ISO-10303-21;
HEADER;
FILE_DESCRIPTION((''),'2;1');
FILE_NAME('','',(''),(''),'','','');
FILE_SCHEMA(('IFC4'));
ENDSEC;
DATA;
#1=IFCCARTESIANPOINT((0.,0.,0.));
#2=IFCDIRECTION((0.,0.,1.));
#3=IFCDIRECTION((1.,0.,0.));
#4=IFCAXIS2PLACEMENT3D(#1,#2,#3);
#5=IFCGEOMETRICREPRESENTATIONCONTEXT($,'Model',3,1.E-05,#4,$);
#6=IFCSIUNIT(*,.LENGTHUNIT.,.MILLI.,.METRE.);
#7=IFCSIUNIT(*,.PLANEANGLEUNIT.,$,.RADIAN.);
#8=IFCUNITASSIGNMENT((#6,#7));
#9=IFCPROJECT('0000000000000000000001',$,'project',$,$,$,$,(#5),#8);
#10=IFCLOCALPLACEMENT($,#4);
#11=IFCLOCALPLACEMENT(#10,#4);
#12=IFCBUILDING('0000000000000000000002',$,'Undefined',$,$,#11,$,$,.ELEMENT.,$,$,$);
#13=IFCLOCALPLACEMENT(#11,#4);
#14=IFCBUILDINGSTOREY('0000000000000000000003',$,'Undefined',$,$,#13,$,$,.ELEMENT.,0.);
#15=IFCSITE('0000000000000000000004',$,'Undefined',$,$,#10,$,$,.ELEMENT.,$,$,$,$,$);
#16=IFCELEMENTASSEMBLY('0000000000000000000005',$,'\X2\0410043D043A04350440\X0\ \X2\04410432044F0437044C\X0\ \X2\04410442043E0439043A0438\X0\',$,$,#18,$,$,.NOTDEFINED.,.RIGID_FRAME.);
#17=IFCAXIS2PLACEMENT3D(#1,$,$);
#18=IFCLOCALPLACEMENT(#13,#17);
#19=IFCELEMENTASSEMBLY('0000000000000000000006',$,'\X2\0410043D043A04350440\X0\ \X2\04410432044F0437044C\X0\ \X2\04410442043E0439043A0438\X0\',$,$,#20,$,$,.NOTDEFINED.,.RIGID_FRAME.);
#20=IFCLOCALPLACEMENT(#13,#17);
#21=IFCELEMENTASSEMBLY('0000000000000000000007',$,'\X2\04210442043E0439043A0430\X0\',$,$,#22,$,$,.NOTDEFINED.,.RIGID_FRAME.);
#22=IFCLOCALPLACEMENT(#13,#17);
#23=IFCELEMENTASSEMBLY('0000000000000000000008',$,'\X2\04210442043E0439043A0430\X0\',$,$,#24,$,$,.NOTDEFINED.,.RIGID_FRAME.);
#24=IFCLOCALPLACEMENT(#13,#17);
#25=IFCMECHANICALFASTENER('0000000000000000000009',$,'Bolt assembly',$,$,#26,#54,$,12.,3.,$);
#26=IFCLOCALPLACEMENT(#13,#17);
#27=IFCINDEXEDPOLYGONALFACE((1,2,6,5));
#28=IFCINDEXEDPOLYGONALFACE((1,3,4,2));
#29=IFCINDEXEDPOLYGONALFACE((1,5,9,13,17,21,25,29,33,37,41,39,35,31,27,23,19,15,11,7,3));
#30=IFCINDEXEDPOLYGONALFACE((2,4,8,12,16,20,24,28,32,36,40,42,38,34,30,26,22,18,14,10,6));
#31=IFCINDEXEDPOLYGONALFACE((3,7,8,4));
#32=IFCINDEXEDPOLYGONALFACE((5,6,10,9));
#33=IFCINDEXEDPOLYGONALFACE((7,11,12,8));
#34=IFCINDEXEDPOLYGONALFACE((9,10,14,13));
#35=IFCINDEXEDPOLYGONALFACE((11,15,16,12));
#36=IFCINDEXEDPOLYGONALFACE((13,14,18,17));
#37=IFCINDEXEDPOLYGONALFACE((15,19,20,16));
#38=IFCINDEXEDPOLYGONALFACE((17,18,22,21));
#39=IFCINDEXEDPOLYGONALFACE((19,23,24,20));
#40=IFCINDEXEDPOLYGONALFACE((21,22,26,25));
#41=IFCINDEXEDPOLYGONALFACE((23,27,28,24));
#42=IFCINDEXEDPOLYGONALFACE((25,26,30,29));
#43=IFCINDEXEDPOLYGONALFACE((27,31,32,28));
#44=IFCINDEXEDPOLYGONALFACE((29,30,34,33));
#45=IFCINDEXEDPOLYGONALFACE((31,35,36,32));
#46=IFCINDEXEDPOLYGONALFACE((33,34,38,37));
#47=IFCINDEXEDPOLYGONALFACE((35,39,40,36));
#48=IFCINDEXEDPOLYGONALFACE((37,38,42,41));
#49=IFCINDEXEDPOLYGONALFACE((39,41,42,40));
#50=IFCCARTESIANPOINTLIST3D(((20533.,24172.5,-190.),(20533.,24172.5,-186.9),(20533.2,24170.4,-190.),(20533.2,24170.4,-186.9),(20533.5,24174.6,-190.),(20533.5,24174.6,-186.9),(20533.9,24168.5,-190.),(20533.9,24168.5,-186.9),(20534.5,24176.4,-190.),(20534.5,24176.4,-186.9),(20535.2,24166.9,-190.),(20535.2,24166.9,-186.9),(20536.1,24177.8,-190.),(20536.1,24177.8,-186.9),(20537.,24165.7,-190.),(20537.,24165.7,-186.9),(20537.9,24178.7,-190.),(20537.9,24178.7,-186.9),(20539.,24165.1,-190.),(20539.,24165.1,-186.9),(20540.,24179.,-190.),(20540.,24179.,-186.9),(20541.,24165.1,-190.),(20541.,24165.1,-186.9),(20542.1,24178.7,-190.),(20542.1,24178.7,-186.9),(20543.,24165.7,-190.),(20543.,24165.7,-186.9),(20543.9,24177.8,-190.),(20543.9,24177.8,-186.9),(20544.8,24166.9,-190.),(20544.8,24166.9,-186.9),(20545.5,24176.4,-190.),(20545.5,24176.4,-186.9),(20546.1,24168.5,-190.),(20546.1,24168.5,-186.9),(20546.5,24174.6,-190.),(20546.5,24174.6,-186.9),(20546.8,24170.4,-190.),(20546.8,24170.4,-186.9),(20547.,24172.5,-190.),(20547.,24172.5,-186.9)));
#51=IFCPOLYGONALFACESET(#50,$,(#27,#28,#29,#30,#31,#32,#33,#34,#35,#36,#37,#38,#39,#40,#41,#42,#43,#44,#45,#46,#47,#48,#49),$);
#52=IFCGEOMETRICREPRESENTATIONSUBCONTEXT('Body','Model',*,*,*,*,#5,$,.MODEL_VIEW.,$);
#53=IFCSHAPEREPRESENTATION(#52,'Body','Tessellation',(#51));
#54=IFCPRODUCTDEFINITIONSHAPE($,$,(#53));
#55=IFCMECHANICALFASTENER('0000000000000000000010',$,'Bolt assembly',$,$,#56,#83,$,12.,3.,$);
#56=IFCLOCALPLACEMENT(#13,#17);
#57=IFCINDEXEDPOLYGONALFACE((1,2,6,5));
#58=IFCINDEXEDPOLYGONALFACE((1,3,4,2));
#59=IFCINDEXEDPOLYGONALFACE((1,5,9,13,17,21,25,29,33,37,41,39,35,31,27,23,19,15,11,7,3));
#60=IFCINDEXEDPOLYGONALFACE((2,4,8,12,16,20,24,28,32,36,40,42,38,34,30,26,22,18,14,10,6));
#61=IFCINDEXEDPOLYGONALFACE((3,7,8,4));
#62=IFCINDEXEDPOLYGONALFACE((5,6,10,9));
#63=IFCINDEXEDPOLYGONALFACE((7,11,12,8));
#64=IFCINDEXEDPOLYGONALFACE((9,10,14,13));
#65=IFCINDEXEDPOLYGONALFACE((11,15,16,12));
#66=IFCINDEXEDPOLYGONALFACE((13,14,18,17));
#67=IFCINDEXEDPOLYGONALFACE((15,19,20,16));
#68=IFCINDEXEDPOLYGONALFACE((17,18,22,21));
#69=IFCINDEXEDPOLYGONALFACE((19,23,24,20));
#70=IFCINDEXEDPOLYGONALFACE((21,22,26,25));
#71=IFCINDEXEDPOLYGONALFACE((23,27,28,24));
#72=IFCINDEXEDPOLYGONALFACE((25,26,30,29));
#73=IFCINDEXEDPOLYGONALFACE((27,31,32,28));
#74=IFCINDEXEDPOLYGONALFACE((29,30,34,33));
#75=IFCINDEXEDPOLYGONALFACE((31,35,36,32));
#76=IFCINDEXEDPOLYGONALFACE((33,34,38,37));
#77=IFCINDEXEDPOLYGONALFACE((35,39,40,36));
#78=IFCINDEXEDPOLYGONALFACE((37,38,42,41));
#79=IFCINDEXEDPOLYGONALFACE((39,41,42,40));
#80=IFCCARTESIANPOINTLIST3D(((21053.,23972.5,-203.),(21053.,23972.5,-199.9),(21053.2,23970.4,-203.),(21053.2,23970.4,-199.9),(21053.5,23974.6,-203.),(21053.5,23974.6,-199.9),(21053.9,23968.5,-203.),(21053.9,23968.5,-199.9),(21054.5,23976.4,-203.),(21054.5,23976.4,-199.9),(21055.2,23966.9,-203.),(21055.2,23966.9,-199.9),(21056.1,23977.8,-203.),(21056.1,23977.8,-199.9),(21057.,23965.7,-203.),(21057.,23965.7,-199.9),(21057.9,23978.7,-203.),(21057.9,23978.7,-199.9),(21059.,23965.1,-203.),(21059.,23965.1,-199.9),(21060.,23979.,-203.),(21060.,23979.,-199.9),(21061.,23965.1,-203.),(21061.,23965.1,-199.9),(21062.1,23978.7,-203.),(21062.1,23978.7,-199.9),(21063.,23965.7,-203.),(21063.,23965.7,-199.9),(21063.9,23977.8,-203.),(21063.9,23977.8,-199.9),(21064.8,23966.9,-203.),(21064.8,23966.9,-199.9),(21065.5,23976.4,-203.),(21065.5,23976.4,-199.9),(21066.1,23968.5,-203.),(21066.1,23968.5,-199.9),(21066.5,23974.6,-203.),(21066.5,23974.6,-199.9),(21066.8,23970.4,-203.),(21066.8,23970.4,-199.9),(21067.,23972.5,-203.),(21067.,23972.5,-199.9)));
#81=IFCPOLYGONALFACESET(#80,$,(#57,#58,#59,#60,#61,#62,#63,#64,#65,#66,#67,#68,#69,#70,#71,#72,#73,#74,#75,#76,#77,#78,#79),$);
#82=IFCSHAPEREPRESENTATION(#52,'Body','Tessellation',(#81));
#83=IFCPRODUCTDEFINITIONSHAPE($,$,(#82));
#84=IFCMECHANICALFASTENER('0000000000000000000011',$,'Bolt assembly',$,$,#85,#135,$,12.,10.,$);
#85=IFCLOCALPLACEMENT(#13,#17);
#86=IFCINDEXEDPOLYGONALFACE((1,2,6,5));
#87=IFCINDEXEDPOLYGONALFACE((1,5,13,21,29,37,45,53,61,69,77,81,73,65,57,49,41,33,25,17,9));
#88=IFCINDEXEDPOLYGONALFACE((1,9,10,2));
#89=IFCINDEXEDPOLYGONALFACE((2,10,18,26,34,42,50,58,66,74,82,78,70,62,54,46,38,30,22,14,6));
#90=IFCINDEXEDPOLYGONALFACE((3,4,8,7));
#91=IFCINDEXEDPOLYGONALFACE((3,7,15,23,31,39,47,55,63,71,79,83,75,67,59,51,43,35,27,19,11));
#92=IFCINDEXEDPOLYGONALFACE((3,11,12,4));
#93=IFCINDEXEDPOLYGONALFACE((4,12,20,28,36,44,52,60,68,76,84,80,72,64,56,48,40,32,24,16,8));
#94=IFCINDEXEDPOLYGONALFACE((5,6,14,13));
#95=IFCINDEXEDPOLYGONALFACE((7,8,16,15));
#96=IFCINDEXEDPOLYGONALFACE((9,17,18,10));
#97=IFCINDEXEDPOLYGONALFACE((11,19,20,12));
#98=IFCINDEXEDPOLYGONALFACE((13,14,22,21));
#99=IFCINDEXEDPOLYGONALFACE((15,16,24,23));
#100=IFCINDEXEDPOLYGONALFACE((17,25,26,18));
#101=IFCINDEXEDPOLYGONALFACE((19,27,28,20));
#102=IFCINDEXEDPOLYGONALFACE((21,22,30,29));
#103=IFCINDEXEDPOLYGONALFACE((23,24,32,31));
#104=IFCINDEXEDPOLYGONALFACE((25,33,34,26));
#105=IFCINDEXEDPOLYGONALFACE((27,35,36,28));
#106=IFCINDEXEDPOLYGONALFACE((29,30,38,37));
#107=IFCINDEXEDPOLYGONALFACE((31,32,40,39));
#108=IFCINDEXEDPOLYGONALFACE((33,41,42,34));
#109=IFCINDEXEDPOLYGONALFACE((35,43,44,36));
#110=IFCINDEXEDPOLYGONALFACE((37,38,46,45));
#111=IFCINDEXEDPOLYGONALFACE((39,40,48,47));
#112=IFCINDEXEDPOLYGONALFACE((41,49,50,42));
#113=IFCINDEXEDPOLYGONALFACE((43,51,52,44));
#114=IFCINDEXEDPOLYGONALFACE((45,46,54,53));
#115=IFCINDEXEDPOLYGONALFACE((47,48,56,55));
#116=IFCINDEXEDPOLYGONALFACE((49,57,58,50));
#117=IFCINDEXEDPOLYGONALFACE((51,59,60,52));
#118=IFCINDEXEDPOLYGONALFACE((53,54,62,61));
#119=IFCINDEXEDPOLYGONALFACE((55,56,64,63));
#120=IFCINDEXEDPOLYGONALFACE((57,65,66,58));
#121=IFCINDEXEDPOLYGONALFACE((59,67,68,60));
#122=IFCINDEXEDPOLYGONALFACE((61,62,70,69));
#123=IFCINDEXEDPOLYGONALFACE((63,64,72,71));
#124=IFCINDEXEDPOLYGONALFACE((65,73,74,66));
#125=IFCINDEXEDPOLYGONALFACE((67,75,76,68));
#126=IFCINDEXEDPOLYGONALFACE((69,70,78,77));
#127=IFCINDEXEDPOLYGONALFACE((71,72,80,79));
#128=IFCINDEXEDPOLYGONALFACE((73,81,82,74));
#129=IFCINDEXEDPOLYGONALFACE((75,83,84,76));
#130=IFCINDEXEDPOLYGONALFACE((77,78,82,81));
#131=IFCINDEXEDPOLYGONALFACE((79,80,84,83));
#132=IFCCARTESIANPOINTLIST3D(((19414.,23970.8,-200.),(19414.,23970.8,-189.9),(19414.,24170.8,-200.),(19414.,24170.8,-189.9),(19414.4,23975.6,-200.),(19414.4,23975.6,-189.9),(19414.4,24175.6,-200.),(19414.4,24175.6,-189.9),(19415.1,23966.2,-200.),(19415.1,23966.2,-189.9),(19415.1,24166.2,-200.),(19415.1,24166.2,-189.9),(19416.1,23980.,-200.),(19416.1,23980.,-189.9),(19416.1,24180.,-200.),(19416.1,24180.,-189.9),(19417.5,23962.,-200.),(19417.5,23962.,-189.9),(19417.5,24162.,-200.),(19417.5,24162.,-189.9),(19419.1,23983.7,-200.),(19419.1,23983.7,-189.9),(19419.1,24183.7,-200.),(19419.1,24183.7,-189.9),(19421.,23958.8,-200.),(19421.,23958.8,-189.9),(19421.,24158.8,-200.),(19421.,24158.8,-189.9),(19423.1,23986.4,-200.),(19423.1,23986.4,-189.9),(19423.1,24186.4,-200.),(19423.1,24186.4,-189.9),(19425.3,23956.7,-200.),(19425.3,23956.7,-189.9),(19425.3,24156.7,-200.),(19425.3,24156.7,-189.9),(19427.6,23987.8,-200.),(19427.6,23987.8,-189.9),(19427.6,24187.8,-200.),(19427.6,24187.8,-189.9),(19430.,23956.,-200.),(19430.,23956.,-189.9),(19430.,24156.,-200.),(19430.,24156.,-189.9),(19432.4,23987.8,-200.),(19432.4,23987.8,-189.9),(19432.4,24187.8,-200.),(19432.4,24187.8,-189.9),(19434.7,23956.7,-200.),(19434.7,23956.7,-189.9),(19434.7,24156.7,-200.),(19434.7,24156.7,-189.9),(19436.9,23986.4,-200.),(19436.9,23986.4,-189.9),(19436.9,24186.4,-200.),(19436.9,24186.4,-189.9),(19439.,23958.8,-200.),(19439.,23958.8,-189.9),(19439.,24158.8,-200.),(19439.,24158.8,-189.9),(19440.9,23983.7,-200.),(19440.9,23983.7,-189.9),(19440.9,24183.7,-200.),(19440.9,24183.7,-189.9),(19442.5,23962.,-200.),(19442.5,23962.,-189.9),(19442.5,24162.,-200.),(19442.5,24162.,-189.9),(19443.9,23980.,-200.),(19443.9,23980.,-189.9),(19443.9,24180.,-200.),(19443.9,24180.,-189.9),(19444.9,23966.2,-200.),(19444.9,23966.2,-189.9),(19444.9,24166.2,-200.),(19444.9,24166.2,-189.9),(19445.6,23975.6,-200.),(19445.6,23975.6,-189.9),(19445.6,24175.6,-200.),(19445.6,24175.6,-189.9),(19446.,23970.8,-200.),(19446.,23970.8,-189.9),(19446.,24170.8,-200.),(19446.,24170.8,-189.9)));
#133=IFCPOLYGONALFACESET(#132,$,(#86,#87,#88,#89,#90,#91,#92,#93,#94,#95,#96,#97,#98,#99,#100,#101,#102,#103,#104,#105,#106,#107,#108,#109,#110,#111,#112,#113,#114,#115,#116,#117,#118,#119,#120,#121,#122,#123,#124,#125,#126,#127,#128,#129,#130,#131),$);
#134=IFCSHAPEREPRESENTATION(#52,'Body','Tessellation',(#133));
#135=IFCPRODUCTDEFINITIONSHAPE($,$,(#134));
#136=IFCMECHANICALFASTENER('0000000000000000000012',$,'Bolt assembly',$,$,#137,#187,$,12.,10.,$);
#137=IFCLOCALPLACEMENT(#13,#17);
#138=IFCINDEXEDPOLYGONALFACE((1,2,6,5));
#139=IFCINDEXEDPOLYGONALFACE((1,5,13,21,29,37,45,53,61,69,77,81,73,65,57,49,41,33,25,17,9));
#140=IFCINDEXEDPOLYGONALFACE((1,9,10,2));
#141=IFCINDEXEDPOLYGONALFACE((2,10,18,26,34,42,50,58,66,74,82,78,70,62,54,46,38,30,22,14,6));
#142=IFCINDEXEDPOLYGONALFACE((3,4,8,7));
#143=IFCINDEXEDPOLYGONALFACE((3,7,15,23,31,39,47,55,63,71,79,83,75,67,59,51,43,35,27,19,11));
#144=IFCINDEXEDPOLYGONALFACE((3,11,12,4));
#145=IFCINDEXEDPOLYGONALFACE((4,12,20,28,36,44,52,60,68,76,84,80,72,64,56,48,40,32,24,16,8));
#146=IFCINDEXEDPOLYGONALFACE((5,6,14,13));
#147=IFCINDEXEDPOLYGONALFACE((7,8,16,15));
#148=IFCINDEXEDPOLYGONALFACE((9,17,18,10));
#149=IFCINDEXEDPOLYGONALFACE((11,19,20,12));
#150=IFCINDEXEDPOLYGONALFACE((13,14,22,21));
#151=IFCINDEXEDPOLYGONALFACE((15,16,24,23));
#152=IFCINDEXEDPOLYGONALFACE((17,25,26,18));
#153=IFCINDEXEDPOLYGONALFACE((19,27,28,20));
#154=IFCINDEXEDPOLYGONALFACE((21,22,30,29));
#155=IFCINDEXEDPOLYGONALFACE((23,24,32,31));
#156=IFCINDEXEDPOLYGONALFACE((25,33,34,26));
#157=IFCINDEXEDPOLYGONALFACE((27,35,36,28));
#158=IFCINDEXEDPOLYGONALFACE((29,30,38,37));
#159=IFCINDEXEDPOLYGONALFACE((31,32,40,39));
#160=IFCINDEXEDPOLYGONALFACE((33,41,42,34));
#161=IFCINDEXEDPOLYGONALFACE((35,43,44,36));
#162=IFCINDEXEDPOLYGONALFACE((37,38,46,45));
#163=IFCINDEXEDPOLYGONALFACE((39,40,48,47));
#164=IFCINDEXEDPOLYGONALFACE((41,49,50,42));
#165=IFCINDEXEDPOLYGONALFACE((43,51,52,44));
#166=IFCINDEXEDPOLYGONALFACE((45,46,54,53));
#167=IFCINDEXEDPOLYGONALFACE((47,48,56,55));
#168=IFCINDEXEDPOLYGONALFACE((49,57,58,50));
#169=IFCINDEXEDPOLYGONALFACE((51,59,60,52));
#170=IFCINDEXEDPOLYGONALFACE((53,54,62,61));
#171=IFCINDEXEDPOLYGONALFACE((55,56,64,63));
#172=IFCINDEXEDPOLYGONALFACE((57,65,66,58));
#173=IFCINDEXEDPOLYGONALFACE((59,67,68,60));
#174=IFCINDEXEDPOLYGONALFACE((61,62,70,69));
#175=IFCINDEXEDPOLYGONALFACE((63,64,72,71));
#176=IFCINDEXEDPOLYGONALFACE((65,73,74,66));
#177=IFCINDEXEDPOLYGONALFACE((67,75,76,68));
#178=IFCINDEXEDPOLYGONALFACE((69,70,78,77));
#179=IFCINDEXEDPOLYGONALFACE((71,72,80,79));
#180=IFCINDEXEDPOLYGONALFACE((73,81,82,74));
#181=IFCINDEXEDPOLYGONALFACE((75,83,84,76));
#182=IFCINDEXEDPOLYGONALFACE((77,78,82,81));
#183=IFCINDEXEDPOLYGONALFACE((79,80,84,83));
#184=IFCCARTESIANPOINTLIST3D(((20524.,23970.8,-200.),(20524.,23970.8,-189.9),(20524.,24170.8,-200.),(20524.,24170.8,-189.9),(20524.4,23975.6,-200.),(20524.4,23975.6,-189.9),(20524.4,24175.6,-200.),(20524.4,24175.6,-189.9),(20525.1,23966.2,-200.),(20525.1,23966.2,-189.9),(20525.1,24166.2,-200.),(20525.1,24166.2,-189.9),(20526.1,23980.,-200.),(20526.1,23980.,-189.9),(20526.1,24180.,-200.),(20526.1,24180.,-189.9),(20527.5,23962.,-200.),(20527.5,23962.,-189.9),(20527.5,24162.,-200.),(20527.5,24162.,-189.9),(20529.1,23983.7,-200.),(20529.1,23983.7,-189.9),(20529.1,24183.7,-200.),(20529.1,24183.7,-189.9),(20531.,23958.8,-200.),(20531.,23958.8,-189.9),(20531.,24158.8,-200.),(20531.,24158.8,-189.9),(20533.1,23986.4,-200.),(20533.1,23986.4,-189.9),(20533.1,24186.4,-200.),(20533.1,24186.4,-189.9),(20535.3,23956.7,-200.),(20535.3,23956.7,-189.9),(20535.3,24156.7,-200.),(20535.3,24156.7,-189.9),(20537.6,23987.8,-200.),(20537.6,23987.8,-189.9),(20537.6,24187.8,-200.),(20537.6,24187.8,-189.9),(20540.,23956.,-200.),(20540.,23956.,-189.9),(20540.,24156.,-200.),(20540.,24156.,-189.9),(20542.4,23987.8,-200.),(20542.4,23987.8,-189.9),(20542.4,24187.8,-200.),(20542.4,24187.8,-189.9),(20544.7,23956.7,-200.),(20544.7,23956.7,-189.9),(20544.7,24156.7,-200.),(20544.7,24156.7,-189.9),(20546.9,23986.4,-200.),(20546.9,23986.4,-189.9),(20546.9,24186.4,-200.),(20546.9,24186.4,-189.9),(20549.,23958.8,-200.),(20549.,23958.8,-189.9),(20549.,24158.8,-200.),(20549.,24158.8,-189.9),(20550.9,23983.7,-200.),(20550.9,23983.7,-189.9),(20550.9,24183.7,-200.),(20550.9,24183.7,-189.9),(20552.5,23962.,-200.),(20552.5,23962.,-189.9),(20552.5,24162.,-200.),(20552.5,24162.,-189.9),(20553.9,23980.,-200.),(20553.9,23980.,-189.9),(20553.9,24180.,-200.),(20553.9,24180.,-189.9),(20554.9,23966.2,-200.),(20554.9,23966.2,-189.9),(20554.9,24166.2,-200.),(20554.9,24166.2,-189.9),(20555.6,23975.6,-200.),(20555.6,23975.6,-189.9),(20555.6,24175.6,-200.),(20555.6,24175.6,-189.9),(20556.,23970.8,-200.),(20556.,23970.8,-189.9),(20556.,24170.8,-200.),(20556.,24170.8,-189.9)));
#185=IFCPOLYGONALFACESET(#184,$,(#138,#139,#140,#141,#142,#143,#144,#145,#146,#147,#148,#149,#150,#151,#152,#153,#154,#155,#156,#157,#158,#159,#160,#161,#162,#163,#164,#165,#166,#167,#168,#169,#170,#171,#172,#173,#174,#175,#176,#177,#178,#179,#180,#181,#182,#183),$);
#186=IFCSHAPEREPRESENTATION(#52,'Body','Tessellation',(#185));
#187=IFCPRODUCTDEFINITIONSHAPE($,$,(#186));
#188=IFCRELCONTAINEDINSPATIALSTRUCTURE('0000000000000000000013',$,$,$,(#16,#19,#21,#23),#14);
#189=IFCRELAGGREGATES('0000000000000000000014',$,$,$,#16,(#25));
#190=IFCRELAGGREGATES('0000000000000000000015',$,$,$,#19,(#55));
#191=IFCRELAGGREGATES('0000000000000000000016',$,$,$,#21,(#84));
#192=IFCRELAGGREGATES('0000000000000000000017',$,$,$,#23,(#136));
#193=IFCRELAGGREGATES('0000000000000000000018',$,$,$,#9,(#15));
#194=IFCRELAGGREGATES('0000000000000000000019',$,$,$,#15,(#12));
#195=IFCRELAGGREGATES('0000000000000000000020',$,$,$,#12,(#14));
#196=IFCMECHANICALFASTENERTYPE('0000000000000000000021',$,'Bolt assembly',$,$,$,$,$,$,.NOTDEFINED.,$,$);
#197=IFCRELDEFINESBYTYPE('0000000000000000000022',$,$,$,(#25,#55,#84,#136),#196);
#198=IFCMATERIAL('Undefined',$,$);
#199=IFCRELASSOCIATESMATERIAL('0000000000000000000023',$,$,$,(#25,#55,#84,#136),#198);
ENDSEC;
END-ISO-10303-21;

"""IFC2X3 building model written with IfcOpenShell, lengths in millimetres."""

from ifc_helpers import new_model, si_unit, frame, origin_with_axes, origin_2d_with_axis, place, context, subcontext, project, spatial, circle, extrude, source, transform, mapped, material, type_object, element, aggregate, save


model = new_model("IFC2X3")

# Units and contexts
model_context = context("Model", 3, precision=1e-05, world=origin_with_axes())
body_context = subcontext(model_context, "Body", "Model", "MODEL_VIEW")
ifc_project = project(units=[si_unit("LENGTHUNIT", "METRE", prefix="MILLI"), si_unit("PLANEANGLEUNIT", "RADIAN")], contexts=[model_context])

# Site, building, storey
site_placement = place(None, origin_with_axes())
site = spatial("IfcSite", under=ifc_project, at=site_placement, Name="Undefined", CompositionType="ELEMENT")
building_placement = place(site_placement, origin_with_axes())
building = spatial("IfcBuilding", under=site, at=building_placement, Name="Undefined", CompositionType="ELEMENT")
storey_placement = place(building_placement, origin_with_axes())
storey = spatial("IfcBuildingStorey", under=building, at=storey_placement, Name="Undefined", CompositionType="ELEMENT", Elevation=0.0)

# Element assemblies
assembly_1_placement = place(storey_placement, origin_with_axes())
assembly_1 = element("IfcElementAssembly", 1, at=assembly_1_placement, inside=storey, Name="Анкер связь стойки", AssemblyPlace="NOTDEFINED", PredefinedType="RIGID_FRAME")
assembly_2_placement = place(storey_placement, origin_with_axes())
assembly_2 = element("IfcElementAssembly", 2, at=assembly_2_placement, inside=storey, Name="Анкер связь стойки", AssemblyPlace="NOTDEFINED", PredefinedType="RIGID_FRAME")

# Element assemblies
assembly_3_placement = place(storey_placement, origin_with_axes())
assembly_3 = element("IfcElementAssembly", 3, at=assembly_3_placement, inside=storey, Name="Стойка", AssemblyPlace="NOTDEFINED", PredefinedType="RIGID_FRAME")
assembly_4_placement = place(storey_placement, origin_with_axes())
assembly_4 = element("IfcElementAssembly", 4, at=assembly_4_placement, inside=storey, Name="Стойка", AssemblyPlace="NOTDEFINED", PredefinedType="RIGID_FRAME")

# Mechanical fasteners
ifc_material_1 = material(Name="Undefined")
mechanical_fastener_type = type_object("IfcMechanicalFastenerType", Name="Bolt assembly")
shared_shape_1 = source(origin_with_axes(), body_context, "Body", "SweptSolid", [
    extrude(circle(Radius=7.0, at=origin_2d_with_axis()), frame((0.0, -3.0, 0.0), z_axis=(0.0, 1.0, 0.0), x_axis=(1.0, 0.0, 0.0)), (0.0, 0.0, 1.0), 3.1),
])
mechanical_fastener_1_placement = place(assembly_1_placement, frame((20540.0, 24172.0, -187.0), z_axis=(1.0, 0.0, 0.0), x_axis=(0.0, 1.0, 0.0)))
mechanical_fastener_1 = element("IfcMechanicalFastener", 5, at=mechanical_fastener_1_placement, type_object=mechanical_fastener_type, material=ifc_material_1, Name="Bolt assembly", NominalDiameter=12.0, NominalLength=3.0, context=body_context, shape_type="MappedRepresentation", body=[
    mapped(shared_shape_1, transform((0.0, 0.0, 0.0))),
])
aggregate(assembly_1, [mechanical_fastener_1])
mechanical_fastener_2_placement = place(assembly_2_placement, frame((21060.0, 23972.0, -200.0), z_axis=(1.0, 0.0, 0.0), x_axis=(0.0, 1.0, 0.0)))
mechanical_fastener_2 = element("IfcMechanicalFastener", 6, at=mechanical_fastener_2_placement, type_object=mechanical_fastener_type, material=ifc_material_1, Name="Bolt assembly", NominalDiameter=12.0, NominalLength=3.0, context=body_context, shape_type="MappedRepresentation", body=[
    mapped(shared_shape_1, transform((0.0, 0.0, 0.0))),
])
aggregate(assembly_2, [mechanical_fastener_2])
shared_shape_2 = source(origin_with_axes(), body_context, "Body", "SweptSolid", [
    extrude(circle(Radius=16.0, at=origin_2d_with_axis()), frame((0.0, -10.0, 0.0), z_axis=(0.0, 1.0, 0.0), x_axis=(1.0, 0.0, 0.0)), (0.0, 0.0, 1.0), 10.1),
])
mechanical_fastener_3_placement = place(assembly_3_placement, frame((19430.0, 24122.0, -190.0), z_axis=(-1.0, 0.0, 0.0), x_axis=(0.0, -1.0, 0.0)))
mechanical_fastener_3 = element("IfcMechanicalFastener", 7, at=mechanical_fastener_3_placement, type_object=mechanical_fastener_type, material=ifc_material_1, Name="Bolt assembly", NominalDiameter=12.0, NominalLength=10.0, context=body_context, shape_type="MappedRepresentation", body=[
    mapped(shared_shape_2, transform((-50.0, 0.0, 0.0))),
    mapped(shared_shape_2, transform((150.0, 0.0, 0.0))),
])
aggregate(assembly_3, [mechanical_fastener_3])
mechanical_fastener_4_placement = place(assembly_4_placement, frame((20540.0, 24122.0, -190.0), z_axis=(-1.0, 0.0, 0.0), x_axis=(0.0, -1.0, 0.0)))
mechanical_fastener_4 = element("IfcMechanicalFastener", 8, at=mechanical_fastener_4_placement, type_object=mechanical_fastener_type, material=ifc_material_1, Name="Bolt assembly", NominalDiameter=12.0, NominalLength=10.0, context=body_context, shape_type="MappedRepresentation", body=[
    mapped(shared_shape_2, transform((-50.0, 0.0, 0.0))),
    mapped(shared_shape_2, transform((150.0, 0.0, 0.0))),
])
aggregate(assembly_4, [mechanical_fastener_4])

save(model, "model.ifc")
